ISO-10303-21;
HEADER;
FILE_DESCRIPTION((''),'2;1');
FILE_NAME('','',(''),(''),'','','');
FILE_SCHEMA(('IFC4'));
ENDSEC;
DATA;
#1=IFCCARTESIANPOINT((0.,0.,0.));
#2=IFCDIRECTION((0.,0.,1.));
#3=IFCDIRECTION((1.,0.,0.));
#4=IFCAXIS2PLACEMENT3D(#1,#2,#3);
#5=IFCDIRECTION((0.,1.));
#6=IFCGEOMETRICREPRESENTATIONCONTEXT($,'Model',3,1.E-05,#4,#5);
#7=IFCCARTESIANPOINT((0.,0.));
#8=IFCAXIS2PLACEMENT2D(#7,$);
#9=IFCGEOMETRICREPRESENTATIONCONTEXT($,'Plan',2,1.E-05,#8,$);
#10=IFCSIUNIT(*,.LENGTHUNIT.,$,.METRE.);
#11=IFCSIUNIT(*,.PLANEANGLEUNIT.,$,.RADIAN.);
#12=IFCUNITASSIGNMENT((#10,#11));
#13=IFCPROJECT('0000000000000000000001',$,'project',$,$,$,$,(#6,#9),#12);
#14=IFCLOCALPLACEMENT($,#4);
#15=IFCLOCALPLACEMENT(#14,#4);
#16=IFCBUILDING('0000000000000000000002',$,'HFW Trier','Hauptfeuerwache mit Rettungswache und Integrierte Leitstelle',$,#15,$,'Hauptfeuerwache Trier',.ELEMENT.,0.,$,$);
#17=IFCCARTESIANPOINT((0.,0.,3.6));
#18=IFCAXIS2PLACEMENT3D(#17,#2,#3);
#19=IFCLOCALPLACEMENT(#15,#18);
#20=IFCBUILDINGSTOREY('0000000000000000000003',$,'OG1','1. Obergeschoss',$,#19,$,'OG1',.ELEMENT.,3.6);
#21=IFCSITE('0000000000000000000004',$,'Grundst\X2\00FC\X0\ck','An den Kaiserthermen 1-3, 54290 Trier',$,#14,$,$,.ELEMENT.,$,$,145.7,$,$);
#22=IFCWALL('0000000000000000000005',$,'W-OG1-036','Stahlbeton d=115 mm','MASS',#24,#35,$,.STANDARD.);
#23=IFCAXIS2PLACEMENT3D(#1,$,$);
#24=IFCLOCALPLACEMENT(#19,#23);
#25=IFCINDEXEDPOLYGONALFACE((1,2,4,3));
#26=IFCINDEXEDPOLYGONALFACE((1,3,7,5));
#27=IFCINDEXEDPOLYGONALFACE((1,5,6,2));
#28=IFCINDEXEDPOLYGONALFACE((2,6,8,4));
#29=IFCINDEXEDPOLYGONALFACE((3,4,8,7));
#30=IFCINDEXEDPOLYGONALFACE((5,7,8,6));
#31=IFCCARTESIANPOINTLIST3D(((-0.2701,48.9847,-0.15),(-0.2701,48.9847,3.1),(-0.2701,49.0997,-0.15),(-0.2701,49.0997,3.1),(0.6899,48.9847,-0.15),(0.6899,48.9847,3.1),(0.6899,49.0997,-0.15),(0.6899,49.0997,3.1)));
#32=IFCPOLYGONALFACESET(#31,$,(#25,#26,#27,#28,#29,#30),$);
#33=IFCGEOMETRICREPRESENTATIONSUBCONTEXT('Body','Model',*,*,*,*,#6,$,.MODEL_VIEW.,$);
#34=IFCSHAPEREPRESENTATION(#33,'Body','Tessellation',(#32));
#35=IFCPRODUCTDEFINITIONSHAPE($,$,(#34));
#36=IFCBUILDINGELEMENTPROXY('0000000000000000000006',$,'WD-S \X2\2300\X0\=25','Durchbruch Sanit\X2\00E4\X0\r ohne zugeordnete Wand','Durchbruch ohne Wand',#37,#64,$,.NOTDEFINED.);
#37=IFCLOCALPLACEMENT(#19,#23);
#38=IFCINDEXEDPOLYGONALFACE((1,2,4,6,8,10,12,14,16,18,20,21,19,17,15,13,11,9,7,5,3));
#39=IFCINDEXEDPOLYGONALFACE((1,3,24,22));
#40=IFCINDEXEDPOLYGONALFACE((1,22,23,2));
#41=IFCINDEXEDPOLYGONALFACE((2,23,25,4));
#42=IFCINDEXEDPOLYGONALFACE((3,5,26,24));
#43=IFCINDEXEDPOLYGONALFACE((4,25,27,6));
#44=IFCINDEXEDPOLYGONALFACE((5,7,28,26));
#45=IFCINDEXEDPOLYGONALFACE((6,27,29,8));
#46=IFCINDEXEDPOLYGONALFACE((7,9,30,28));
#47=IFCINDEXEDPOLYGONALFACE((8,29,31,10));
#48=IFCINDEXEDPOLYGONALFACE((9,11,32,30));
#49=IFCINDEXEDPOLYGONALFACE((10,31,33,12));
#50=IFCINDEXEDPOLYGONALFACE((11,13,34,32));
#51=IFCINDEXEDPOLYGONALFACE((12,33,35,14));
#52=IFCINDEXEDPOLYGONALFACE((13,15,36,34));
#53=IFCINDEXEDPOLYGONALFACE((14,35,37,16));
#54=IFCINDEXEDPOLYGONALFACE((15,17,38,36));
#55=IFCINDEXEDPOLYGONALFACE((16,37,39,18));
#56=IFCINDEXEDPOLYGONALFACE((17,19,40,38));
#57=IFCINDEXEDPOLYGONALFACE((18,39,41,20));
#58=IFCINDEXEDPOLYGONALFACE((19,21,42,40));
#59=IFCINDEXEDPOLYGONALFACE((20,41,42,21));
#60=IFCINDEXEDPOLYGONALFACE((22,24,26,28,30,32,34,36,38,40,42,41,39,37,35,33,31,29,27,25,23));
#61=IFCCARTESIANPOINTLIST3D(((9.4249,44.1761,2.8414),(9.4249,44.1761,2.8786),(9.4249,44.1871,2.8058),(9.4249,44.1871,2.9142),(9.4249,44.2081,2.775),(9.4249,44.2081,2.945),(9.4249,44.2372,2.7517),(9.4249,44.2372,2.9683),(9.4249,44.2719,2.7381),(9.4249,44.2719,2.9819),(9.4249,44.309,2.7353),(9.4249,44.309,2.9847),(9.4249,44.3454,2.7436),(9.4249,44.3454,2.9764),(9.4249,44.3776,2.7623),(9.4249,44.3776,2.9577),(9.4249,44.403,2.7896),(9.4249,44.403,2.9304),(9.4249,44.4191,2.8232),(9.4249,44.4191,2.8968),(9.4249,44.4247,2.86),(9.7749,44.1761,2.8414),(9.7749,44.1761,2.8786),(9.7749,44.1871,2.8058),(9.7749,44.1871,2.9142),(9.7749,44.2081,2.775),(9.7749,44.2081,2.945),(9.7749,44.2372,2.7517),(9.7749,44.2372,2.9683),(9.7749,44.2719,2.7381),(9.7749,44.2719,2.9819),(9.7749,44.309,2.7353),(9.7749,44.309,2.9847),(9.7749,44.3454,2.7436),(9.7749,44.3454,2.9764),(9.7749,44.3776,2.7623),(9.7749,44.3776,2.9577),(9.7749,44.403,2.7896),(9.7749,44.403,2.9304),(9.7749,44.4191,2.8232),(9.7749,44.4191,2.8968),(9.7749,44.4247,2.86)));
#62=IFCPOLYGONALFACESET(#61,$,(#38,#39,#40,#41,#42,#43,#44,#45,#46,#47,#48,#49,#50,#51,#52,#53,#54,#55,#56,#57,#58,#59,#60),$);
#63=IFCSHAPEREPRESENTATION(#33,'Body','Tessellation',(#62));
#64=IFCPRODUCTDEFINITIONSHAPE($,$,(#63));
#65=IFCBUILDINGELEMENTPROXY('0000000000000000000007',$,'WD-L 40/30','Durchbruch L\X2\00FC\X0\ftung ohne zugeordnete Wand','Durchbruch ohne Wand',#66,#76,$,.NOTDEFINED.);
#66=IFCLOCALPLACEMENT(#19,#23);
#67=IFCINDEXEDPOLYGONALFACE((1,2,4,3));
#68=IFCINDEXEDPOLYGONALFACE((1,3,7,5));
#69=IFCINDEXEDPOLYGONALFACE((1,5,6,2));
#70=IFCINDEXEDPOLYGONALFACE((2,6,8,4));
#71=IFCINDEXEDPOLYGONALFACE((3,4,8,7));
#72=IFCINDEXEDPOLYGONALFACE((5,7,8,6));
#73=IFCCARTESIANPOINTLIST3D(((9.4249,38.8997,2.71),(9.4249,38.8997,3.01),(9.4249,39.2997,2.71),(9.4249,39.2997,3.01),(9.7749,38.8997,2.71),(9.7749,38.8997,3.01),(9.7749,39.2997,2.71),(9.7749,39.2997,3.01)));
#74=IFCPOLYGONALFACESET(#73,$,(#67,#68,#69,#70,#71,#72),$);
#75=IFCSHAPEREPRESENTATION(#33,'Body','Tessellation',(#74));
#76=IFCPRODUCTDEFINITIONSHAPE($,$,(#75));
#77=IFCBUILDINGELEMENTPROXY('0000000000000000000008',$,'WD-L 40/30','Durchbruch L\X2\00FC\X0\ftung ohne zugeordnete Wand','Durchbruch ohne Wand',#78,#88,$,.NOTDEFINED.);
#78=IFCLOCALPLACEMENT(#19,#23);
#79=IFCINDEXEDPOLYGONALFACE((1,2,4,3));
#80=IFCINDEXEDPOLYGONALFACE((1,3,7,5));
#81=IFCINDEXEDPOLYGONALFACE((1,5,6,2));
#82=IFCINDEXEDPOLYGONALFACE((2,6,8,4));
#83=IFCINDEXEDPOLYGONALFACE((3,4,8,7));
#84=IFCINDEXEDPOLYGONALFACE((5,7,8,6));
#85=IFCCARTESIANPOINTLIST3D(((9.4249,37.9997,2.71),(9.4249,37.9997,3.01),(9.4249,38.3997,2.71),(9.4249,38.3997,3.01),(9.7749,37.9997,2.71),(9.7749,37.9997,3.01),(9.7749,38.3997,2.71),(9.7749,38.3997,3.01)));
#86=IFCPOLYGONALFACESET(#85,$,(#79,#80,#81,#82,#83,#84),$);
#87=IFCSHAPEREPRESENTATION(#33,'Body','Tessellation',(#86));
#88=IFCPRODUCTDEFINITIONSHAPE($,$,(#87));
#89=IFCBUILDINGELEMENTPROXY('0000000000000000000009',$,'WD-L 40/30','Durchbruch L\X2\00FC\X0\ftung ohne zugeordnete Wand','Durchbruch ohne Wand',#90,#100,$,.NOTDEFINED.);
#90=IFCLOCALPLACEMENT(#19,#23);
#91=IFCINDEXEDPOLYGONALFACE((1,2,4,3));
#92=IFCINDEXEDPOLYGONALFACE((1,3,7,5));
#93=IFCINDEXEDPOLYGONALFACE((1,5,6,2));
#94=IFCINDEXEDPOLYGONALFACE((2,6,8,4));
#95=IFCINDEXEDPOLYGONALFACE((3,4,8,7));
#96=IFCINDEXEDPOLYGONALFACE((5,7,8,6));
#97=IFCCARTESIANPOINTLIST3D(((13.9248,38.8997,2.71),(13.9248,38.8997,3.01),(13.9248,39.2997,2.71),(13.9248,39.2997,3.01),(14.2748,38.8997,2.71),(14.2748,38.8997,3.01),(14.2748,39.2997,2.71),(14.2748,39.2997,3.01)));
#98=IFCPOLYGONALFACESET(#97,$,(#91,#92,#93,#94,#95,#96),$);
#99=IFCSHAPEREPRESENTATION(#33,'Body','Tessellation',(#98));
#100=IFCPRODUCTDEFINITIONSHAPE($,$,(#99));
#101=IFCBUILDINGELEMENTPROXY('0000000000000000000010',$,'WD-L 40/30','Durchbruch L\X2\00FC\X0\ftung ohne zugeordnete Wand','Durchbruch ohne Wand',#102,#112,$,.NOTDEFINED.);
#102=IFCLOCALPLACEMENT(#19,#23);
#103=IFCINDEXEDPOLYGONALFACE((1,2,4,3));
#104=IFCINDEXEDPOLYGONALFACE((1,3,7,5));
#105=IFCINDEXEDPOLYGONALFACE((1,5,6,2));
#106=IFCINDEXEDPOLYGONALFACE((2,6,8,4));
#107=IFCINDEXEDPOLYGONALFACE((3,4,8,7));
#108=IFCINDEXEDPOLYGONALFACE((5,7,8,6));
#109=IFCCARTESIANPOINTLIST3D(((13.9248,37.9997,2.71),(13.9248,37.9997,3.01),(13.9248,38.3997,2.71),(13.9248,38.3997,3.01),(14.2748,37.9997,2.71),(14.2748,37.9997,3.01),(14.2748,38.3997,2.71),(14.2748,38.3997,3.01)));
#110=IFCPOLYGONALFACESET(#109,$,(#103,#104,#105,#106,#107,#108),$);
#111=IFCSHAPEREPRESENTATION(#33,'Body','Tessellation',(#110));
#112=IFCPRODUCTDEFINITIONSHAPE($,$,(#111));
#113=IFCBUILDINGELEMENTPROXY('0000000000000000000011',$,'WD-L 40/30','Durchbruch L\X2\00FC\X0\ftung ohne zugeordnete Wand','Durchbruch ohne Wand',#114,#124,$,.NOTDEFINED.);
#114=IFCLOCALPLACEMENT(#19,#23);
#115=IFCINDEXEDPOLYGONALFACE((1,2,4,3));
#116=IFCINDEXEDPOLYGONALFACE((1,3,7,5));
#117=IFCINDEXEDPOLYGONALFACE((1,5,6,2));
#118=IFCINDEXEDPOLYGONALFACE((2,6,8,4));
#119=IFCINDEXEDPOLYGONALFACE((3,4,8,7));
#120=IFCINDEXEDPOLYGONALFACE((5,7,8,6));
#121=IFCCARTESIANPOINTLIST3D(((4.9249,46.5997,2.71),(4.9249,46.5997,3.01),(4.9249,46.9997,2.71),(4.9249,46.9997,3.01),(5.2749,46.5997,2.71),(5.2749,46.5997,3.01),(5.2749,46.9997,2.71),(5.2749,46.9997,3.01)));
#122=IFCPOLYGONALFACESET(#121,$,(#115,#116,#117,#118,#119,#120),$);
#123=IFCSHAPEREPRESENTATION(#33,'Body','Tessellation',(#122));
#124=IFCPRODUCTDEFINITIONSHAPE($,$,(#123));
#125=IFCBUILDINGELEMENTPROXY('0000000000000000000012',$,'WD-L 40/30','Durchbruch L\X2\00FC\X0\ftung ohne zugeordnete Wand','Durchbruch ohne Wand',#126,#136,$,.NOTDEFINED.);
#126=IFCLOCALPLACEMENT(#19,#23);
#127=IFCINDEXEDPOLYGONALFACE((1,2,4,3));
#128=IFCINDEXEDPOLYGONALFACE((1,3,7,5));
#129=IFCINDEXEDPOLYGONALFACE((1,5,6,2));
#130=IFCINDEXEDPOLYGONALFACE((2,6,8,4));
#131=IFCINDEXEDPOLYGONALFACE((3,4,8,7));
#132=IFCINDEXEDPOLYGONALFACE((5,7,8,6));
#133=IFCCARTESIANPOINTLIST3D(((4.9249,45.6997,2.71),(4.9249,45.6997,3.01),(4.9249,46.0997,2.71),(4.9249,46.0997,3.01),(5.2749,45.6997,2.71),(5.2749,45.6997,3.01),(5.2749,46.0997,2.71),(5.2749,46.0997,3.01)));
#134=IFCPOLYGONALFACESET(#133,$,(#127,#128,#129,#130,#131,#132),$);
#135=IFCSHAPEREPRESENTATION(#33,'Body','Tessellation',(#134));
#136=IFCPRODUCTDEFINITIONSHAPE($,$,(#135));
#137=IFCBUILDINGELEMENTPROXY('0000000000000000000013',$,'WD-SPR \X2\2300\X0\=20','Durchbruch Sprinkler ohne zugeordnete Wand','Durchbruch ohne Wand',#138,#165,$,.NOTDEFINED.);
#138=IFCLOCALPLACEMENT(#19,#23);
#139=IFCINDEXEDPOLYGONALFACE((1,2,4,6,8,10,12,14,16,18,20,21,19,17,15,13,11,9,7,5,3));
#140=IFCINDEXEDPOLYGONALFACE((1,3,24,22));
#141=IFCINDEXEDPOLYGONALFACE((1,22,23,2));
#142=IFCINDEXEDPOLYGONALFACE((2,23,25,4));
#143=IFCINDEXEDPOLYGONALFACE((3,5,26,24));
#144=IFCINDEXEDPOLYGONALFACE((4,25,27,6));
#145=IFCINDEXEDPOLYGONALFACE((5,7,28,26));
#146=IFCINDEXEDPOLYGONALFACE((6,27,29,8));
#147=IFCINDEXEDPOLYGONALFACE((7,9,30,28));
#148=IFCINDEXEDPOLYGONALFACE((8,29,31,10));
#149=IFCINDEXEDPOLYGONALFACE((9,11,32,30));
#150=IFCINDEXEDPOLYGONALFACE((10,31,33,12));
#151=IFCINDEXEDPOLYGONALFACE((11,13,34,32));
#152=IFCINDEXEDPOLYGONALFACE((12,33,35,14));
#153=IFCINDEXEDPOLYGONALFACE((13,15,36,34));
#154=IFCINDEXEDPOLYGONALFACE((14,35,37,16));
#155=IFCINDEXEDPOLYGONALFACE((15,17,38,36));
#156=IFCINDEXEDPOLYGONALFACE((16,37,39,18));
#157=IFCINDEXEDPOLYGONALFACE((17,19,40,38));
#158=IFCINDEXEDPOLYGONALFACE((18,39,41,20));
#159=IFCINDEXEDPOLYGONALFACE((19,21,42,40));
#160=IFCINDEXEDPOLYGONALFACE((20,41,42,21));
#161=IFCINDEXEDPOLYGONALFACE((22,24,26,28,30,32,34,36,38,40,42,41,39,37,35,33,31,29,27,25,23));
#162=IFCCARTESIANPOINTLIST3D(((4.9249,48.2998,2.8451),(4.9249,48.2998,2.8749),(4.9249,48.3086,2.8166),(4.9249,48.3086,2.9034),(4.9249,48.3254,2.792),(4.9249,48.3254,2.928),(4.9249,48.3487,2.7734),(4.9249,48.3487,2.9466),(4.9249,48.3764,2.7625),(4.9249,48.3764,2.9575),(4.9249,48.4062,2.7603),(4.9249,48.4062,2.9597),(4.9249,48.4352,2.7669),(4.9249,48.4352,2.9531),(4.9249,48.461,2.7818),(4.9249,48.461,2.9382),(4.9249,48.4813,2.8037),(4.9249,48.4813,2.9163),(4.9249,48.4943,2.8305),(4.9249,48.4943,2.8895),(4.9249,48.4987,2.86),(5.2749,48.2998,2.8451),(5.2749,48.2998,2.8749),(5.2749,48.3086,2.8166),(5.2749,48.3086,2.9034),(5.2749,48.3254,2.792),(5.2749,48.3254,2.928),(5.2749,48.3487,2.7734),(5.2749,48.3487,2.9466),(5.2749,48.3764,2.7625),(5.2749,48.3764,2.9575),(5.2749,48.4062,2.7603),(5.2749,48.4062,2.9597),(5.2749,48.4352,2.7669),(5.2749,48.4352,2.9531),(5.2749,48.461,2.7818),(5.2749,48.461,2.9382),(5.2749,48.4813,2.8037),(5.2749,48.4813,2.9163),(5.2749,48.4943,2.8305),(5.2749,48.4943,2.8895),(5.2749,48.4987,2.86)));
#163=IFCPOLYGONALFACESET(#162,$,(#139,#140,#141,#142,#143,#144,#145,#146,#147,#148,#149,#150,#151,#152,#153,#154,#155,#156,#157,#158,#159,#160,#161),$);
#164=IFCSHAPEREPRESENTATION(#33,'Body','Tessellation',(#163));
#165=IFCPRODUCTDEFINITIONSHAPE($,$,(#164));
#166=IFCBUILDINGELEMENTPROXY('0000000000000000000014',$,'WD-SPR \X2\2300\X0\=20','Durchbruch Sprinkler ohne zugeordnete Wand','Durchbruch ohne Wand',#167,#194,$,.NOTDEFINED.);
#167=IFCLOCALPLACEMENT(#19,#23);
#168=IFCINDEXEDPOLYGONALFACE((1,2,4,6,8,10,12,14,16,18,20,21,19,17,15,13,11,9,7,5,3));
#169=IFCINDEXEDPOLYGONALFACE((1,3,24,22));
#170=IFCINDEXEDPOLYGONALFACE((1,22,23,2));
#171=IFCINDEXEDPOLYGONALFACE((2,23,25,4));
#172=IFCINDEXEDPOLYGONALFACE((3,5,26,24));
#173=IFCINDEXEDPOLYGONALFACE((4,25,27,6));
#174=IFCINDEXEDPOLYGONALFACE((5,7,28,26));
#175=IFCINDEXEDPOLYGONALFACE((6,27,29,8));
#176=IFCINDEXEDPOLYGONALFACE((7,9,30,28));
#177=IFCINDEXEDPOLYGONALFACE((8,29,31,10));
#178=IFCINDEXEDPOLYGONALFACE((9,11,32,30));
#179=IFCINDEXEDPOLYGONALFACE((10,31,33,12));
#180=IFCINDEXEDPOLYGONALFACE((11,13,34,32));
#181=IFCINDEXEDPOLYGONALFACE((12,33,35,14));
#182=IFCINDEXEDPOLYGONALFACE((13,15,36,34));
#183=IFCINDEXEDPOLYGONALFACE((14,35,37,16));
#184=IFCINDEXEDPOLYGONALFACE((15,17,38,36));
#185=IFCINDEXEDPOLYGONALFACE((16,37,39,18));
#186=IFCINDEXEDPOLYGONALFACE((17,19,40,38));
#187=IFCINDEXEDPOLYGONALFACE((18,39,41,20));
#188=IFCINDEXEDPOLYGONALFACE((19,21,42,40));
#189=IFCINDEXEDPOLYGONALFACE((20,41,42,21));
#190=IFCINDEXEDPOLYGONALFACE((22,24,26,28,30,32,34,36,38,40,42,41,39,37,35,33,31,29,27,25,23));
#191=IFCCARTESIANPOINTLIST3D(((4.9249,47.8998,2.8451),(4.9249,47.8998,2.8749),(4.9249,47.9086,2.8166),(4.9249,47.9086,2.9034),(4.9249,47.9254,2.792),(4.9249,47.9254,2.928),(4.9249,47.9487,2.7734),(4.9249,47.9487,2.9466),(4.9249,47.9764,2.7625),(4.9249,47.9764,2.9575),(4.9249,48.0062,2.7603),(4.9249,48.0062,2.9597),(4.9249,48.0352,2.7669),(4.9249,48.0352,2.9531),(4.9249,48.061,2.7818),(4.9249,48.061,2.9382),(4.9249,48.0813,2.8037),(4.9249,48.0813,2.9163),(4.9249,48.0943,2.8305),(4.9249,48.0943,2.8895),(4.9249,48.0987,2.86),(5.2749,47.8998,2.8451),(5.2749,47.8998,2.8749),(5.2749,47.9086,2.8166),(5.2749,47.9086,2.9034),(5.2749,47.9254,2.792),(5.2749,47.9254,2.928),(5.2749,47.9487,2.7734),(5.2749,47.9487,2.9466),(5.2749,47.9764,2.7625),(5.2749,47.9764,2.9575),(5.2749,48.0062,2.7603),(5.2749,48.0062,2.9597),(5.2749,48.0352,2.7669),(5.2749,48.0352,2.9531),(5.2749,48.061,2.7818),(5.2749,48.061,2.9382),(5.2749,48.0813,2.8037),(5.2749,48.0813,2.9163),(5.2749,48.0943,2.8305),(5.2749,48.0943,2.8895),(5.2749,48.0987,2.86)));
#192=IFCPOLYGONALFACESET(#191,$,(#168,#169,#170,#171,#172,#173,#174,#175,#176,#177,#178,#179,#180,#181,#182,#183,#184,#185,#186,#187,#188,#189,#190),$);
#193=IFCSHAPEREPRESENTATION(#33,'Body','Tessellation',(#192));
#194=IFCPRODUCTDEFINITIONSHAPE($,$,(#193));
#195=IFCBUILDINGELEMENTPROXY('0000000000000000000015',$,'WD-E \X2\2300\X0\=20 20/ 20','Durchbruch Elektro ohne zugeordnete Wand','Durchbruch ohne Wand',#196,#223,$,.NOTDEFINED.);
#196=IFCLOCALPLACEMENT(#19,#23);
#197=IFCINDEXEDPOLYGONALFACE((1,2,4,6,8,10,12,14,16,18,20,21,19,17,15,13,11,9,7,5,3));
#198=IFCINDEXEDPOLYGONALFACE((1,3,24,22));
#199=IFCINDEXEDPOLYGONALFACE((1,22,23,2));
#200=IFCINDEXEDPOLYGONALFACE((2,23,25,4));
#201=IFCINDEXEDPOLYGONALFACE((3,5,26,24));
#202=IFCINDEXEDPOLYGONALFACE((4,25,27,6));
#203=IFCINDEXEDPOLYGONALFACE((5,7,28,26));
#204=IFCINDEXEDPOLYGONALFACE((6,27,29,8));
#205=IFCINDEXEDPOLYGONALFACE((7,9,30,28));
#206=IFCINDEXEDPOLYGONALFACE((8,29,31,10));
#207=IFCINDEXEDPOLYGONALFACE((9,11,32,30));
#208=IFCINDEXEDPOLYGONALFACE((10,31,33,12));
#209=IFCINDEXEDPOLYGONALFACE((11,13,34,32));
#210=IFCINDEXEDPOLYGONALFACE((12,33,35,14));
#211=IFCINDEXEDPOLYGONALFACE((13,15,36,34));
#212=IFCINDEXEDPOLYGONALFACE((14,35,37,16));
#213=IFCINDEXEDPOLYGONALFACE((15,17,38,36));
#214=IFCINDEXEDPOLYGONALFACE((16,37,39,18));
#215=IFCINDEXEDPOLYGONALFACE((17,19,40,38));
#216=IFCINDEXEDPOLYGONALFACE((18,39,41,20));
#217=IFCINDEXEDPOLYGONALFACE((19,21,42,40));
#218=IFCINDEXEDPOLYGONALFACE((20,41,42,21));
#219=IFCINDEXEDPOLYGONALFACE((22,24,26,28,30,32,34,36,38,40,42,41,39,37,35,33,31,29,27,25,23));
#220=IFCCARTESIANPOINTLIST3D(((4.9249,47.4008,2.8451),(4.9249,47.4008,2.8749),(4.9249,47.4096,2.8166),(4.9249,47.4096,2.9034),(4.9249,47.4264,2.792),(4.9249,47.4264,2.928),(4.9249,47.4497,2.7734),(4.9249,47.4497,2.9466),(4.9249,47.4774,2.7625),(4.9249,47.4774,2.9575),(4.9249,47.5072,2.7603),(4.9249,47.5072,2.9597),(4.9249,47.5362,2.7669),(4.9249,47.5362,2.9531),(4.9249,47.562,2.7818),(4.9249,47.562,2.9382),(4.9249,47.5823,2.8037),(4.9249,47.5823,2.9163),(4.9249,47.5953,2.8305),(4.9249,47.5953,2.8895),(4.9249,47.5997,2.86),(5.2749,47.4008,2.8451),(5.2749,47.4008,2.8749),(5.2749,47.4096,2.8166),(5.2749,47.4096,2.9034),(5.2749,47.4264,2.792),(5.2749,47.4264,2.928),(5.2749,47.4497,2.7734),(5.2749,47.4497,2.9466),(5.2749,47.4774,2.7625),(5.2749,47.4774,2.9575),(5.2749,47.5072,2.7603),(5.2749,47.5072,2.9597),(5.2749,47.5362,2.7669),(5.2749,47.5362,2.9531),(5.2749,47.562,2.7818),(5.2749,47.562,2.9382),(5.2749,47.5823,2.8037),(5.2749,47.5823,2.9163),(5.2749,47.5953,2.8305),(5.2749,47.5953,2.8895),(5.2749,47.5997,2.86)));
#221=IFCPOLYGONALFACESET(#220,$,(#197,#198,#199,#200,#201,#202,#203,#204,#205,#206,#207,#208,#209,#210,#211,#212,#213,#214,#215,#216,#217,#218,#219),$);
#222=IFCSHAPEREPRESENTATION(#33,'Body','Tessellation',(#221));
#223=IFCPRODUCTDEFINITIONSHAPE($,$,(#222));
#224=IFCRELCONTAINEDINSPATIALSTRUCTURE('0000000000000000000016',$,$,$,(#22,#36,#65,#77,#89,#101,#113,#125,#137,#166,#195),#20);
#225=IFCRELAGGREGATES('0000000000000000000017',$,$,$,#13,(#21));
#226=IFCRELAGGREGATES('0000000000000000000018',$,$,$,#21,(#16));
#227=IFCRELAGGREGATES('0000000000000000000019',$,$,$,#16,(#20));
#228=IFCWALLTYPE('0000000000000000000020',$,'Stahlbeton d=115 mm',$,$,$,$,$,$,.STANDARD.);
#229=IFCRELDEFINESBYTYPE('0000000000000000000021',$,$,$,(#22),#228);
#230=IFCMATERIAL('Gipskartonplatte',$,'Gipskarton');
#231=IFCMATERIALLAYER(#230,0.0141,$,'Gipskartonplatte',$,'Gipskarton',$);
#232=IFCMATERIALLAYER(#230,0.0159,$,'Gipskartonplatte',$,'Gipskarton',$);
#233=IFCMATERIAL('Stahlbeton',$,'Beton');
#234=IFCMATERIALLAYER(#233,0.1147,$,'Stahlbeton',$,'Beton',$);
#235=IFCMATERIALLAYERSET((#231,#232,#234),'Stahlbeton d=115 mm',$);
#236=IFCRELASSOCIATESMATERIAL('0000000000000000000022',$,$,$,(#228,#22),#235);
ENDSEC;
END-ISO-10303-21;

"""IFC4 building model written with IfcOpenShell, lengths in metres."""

from ifc_helpers import new_model, si_unit, direction, frame, frame_2d, origin_with_axes, origin_2d, place, context, subcontext, project, spatial, rectangle, circle, extrude, material, layer, layer_set, layer_usage, type_object, element, save


model = new_model("IFC4")

# Units and contexts
model_context = context("Model", 3, precision=1e-05, world=origin_with_axes(), true_north=direction((0.0, 1.0)))
plan_context = context("Plan", 2, precision=1e-05, world=origin_2d())
body_context = subcontext(model_context, "Body", "Model", "MODEL_VIEW")
ifc_project = project(units=[si_unit("LENGTHUNIT", "METRE"), si_unit("PLANEANGLEUNIT", "RADIAN")], contexts=[model_context, plan_context])

# Site, building, storey
site_placement = place(None, origin_with_axes())
site = spatial("IfcSite", under=ifc_project, at=site_placement, Name="Grundstück", Description="An den Kaiserthermen 1-3, 54290 Trier", CompositionType="ELEMENT", RefElevation=145.7)
building_placement = place(site_placement, origin_with_axes())
building = spatial("IfcBuilding", under=site, at=building_placement, Name="HFW Trier", Description="Hauptfeuerwache mit Rettungswache und Integrierte Leitstelle", LongName="Hauptfeuerwache Trier", CompositionType="ELEMENT", ElevationOfRefHeight=0.0)
storey_placement = place(building_placement, frame((0.0, 0.0, 3.6), z_axis=(0.0, 0.0, 1.0), x_axis=(1.0, 0.0, 0.0)))
storey = spatial("IfcBuildingStorey", under=building, at=storey_placement, Name="OG1", Description="1. Obergeschoss", LongName="OG1", CompositionType="ELEMENT", Elevation=3.6)

# Shared definitions
ifc_material_1 = material(Name="Stahlbeton", Category="Beton")

# Wall
ifc_material_2 = material(Name="Gipskartonplatte", Category="Gipskarton")
ifc_layer_1 = layer(ifc_material_2, 0.0141, Name="Gipskartonplatte", Category="Gipskarton")
ifc_layer_2 = layer(ifc_material_2, 0.0159, Name="Gipskartonplatte", Category="Gipskarton")
ifc_layer_3 = layer(ifc_material_1, 0.1147, Name="Stahlbeton", Category="Beton")
ifc_layer_set_1 = layer_set([ifc_layer_1, ifc_layer_2, ifc_layer_3], Name="Stahlbeton d=115 mm")
ifc_layer_usage_1 = layer_usage(ifc_layer_set_1, "AXIS2", "POSITIVE", -0.0575)
wall_type_1 = type_object("IfcWallType", Name="Stahlbeton d=115 mm", PredefinedType="STANDARD", material=ifc_layer_set_1)
wall_1_placement = place(storey_placement, frame((-0.2701, 49.0422, -0.15), z_axis=(0.0, 0.0, 1.0), x_axis=(1.0, 0.0, 0.0)))
element("IfcWall", 1, at=wall_1_placement, inside=storey, type_object=wall_type_1, material=ifc_layer_usage_1, Name="W-OG1-036", Description="Stahlbeton d=115 mm", ObjectType="MASS", PredefinedType="STANDARD", context=body_context, shape_type="SweptSolid", body=[
    extrude(rectangle(XDim=0.96, YDim=0.115, at=frame_2d((0.48, 0.0))), origin_with_axes(), (0.0, 0.0, 1.0), 3.25),
])

# Building element proxies
proxy_1_placement = place(storey_placement, frame((9.5999, 44.2997, 2.735), z_axis=(0.0, 0.0, 1.0), x_axis=(0.0, 1.0, 0.0)))
element("IfcBuildingElementProxy", 2, at=proxy_1_placement, inside=storey, Name="WD-S ⌀=25", Description="Durchbruch Sanitär ohne zugeordnete Wand", ObjectType="Durchbruch ohne Wand", PredefinedType="NOTDEFINED", context=body_context, shape_type="SweptSolid", body=[
    extrude(circle(Radius=0.125, at=origin_2d()), frame((0.0, -0.175, 0.125), z_axis=(0.0, 1.0, 0.0), x_axis=(1.0, 0.0, 0.0)), (0.0, 0.0, 1.0), 0.35),
])
for number, where, z_axis, x_axis, name in (
    (3, (9.5999, 39.0997, 2.71), (0.0, 0.0, 1.0), (0.0, 1.0, 0.0), "WD-L 40/30"),
    (4, (9.5999, 38.1997, 2.71), (0.0, 0.0, 1.0), (0.0, 1.0, 0.0), "WD-L 40/30"),
    (5, (14.0998, 39.0997, 2.71), (0.0, 0.0, 1.0), (0.0, 1.0, 0.0), "WD-L 40/30"),
    (6, (14.0998, 38.1997, 2.71), (0.0, 0.0, 1.0), (0.0, 1.0, 0.0), "WD-L 40/30"),
    (7, (5.0999, 46.7997, 2.71), (0.0, 0.0, 1.0), (0.0, 1.0, 0.0), "WD-L 40/30"),
    (8, (5.0999, 45.8997, 2.71), (0.0, 0.0, 1.0), (0.0, 1.0, 0.0), "WD-L 40/30"),
):
    element("IfcBuildingElementProxy", number, at=place(storey_placement, frame(where, z_axis=z_axis, x_axis=x_axis)), inside=storey, Name=name, Description="Durchbruch Lüftung ohne zugeordnete Wand", ObjectType="Durchbruch ohne Wand", PredefinedType="NOTDEFINED", context=body_context, shape_type="SweptSolid", body=[
        extrude(rectangle(XDim=0.4, YDim=0.35, at=origin_2d()), origin_with_axes(), (0.0, 0.0, 1.0), 0.3),
    ])
for number, where, z_axis, x_axis, name, description in (
    (9, (5.0999, 48.3987, 2.76), (0.0, 0.0, 1.0), (0.0, 1.0, 0.0), "WD-SPR ⌀=20", "Durchbruch Sprinkler ohne zugeordnete Wand"),
    (10, (5.0999, 47.9987, 2.76), (0.0, 0.0, 1.0), (0.0, 1.0, 0.0), "WD-SPR ⌀=20", "Durchbruch Sprinkler ohne zugeordnete Wand"),
    (11, (5.0999, 47.4997, 2.76), (0.0, 0.0, 1.0), (0.0, 1.0, 0.0), "WD-E ⌀=20 20/ 20", "Durchbruch Elektro ohne zugeordnete Wand"),
):
    element("IfcBuildingElementProxy", number, at=place(storey_placement, frame(where, z_axis=z_axis, x_axis=x_axis)), inside=storey, Name=name, Description=description, ObjectType="Durchbruch ohne Wand", PredefinedType="NOTDEFINED", context=body_context, shape_type="SweptSolid", body=[
        extrude(circle(Radius=0.1, at=origin_2d()), frame((0.0, -0.175, 0.1), z_axis=(0.0, 1.0, 0.0), x_axis=(1.0, 0.0, 0.0)), (0.0, 0.0, 1.0), 0.35),
    ])

save(model, "model.ifc")
